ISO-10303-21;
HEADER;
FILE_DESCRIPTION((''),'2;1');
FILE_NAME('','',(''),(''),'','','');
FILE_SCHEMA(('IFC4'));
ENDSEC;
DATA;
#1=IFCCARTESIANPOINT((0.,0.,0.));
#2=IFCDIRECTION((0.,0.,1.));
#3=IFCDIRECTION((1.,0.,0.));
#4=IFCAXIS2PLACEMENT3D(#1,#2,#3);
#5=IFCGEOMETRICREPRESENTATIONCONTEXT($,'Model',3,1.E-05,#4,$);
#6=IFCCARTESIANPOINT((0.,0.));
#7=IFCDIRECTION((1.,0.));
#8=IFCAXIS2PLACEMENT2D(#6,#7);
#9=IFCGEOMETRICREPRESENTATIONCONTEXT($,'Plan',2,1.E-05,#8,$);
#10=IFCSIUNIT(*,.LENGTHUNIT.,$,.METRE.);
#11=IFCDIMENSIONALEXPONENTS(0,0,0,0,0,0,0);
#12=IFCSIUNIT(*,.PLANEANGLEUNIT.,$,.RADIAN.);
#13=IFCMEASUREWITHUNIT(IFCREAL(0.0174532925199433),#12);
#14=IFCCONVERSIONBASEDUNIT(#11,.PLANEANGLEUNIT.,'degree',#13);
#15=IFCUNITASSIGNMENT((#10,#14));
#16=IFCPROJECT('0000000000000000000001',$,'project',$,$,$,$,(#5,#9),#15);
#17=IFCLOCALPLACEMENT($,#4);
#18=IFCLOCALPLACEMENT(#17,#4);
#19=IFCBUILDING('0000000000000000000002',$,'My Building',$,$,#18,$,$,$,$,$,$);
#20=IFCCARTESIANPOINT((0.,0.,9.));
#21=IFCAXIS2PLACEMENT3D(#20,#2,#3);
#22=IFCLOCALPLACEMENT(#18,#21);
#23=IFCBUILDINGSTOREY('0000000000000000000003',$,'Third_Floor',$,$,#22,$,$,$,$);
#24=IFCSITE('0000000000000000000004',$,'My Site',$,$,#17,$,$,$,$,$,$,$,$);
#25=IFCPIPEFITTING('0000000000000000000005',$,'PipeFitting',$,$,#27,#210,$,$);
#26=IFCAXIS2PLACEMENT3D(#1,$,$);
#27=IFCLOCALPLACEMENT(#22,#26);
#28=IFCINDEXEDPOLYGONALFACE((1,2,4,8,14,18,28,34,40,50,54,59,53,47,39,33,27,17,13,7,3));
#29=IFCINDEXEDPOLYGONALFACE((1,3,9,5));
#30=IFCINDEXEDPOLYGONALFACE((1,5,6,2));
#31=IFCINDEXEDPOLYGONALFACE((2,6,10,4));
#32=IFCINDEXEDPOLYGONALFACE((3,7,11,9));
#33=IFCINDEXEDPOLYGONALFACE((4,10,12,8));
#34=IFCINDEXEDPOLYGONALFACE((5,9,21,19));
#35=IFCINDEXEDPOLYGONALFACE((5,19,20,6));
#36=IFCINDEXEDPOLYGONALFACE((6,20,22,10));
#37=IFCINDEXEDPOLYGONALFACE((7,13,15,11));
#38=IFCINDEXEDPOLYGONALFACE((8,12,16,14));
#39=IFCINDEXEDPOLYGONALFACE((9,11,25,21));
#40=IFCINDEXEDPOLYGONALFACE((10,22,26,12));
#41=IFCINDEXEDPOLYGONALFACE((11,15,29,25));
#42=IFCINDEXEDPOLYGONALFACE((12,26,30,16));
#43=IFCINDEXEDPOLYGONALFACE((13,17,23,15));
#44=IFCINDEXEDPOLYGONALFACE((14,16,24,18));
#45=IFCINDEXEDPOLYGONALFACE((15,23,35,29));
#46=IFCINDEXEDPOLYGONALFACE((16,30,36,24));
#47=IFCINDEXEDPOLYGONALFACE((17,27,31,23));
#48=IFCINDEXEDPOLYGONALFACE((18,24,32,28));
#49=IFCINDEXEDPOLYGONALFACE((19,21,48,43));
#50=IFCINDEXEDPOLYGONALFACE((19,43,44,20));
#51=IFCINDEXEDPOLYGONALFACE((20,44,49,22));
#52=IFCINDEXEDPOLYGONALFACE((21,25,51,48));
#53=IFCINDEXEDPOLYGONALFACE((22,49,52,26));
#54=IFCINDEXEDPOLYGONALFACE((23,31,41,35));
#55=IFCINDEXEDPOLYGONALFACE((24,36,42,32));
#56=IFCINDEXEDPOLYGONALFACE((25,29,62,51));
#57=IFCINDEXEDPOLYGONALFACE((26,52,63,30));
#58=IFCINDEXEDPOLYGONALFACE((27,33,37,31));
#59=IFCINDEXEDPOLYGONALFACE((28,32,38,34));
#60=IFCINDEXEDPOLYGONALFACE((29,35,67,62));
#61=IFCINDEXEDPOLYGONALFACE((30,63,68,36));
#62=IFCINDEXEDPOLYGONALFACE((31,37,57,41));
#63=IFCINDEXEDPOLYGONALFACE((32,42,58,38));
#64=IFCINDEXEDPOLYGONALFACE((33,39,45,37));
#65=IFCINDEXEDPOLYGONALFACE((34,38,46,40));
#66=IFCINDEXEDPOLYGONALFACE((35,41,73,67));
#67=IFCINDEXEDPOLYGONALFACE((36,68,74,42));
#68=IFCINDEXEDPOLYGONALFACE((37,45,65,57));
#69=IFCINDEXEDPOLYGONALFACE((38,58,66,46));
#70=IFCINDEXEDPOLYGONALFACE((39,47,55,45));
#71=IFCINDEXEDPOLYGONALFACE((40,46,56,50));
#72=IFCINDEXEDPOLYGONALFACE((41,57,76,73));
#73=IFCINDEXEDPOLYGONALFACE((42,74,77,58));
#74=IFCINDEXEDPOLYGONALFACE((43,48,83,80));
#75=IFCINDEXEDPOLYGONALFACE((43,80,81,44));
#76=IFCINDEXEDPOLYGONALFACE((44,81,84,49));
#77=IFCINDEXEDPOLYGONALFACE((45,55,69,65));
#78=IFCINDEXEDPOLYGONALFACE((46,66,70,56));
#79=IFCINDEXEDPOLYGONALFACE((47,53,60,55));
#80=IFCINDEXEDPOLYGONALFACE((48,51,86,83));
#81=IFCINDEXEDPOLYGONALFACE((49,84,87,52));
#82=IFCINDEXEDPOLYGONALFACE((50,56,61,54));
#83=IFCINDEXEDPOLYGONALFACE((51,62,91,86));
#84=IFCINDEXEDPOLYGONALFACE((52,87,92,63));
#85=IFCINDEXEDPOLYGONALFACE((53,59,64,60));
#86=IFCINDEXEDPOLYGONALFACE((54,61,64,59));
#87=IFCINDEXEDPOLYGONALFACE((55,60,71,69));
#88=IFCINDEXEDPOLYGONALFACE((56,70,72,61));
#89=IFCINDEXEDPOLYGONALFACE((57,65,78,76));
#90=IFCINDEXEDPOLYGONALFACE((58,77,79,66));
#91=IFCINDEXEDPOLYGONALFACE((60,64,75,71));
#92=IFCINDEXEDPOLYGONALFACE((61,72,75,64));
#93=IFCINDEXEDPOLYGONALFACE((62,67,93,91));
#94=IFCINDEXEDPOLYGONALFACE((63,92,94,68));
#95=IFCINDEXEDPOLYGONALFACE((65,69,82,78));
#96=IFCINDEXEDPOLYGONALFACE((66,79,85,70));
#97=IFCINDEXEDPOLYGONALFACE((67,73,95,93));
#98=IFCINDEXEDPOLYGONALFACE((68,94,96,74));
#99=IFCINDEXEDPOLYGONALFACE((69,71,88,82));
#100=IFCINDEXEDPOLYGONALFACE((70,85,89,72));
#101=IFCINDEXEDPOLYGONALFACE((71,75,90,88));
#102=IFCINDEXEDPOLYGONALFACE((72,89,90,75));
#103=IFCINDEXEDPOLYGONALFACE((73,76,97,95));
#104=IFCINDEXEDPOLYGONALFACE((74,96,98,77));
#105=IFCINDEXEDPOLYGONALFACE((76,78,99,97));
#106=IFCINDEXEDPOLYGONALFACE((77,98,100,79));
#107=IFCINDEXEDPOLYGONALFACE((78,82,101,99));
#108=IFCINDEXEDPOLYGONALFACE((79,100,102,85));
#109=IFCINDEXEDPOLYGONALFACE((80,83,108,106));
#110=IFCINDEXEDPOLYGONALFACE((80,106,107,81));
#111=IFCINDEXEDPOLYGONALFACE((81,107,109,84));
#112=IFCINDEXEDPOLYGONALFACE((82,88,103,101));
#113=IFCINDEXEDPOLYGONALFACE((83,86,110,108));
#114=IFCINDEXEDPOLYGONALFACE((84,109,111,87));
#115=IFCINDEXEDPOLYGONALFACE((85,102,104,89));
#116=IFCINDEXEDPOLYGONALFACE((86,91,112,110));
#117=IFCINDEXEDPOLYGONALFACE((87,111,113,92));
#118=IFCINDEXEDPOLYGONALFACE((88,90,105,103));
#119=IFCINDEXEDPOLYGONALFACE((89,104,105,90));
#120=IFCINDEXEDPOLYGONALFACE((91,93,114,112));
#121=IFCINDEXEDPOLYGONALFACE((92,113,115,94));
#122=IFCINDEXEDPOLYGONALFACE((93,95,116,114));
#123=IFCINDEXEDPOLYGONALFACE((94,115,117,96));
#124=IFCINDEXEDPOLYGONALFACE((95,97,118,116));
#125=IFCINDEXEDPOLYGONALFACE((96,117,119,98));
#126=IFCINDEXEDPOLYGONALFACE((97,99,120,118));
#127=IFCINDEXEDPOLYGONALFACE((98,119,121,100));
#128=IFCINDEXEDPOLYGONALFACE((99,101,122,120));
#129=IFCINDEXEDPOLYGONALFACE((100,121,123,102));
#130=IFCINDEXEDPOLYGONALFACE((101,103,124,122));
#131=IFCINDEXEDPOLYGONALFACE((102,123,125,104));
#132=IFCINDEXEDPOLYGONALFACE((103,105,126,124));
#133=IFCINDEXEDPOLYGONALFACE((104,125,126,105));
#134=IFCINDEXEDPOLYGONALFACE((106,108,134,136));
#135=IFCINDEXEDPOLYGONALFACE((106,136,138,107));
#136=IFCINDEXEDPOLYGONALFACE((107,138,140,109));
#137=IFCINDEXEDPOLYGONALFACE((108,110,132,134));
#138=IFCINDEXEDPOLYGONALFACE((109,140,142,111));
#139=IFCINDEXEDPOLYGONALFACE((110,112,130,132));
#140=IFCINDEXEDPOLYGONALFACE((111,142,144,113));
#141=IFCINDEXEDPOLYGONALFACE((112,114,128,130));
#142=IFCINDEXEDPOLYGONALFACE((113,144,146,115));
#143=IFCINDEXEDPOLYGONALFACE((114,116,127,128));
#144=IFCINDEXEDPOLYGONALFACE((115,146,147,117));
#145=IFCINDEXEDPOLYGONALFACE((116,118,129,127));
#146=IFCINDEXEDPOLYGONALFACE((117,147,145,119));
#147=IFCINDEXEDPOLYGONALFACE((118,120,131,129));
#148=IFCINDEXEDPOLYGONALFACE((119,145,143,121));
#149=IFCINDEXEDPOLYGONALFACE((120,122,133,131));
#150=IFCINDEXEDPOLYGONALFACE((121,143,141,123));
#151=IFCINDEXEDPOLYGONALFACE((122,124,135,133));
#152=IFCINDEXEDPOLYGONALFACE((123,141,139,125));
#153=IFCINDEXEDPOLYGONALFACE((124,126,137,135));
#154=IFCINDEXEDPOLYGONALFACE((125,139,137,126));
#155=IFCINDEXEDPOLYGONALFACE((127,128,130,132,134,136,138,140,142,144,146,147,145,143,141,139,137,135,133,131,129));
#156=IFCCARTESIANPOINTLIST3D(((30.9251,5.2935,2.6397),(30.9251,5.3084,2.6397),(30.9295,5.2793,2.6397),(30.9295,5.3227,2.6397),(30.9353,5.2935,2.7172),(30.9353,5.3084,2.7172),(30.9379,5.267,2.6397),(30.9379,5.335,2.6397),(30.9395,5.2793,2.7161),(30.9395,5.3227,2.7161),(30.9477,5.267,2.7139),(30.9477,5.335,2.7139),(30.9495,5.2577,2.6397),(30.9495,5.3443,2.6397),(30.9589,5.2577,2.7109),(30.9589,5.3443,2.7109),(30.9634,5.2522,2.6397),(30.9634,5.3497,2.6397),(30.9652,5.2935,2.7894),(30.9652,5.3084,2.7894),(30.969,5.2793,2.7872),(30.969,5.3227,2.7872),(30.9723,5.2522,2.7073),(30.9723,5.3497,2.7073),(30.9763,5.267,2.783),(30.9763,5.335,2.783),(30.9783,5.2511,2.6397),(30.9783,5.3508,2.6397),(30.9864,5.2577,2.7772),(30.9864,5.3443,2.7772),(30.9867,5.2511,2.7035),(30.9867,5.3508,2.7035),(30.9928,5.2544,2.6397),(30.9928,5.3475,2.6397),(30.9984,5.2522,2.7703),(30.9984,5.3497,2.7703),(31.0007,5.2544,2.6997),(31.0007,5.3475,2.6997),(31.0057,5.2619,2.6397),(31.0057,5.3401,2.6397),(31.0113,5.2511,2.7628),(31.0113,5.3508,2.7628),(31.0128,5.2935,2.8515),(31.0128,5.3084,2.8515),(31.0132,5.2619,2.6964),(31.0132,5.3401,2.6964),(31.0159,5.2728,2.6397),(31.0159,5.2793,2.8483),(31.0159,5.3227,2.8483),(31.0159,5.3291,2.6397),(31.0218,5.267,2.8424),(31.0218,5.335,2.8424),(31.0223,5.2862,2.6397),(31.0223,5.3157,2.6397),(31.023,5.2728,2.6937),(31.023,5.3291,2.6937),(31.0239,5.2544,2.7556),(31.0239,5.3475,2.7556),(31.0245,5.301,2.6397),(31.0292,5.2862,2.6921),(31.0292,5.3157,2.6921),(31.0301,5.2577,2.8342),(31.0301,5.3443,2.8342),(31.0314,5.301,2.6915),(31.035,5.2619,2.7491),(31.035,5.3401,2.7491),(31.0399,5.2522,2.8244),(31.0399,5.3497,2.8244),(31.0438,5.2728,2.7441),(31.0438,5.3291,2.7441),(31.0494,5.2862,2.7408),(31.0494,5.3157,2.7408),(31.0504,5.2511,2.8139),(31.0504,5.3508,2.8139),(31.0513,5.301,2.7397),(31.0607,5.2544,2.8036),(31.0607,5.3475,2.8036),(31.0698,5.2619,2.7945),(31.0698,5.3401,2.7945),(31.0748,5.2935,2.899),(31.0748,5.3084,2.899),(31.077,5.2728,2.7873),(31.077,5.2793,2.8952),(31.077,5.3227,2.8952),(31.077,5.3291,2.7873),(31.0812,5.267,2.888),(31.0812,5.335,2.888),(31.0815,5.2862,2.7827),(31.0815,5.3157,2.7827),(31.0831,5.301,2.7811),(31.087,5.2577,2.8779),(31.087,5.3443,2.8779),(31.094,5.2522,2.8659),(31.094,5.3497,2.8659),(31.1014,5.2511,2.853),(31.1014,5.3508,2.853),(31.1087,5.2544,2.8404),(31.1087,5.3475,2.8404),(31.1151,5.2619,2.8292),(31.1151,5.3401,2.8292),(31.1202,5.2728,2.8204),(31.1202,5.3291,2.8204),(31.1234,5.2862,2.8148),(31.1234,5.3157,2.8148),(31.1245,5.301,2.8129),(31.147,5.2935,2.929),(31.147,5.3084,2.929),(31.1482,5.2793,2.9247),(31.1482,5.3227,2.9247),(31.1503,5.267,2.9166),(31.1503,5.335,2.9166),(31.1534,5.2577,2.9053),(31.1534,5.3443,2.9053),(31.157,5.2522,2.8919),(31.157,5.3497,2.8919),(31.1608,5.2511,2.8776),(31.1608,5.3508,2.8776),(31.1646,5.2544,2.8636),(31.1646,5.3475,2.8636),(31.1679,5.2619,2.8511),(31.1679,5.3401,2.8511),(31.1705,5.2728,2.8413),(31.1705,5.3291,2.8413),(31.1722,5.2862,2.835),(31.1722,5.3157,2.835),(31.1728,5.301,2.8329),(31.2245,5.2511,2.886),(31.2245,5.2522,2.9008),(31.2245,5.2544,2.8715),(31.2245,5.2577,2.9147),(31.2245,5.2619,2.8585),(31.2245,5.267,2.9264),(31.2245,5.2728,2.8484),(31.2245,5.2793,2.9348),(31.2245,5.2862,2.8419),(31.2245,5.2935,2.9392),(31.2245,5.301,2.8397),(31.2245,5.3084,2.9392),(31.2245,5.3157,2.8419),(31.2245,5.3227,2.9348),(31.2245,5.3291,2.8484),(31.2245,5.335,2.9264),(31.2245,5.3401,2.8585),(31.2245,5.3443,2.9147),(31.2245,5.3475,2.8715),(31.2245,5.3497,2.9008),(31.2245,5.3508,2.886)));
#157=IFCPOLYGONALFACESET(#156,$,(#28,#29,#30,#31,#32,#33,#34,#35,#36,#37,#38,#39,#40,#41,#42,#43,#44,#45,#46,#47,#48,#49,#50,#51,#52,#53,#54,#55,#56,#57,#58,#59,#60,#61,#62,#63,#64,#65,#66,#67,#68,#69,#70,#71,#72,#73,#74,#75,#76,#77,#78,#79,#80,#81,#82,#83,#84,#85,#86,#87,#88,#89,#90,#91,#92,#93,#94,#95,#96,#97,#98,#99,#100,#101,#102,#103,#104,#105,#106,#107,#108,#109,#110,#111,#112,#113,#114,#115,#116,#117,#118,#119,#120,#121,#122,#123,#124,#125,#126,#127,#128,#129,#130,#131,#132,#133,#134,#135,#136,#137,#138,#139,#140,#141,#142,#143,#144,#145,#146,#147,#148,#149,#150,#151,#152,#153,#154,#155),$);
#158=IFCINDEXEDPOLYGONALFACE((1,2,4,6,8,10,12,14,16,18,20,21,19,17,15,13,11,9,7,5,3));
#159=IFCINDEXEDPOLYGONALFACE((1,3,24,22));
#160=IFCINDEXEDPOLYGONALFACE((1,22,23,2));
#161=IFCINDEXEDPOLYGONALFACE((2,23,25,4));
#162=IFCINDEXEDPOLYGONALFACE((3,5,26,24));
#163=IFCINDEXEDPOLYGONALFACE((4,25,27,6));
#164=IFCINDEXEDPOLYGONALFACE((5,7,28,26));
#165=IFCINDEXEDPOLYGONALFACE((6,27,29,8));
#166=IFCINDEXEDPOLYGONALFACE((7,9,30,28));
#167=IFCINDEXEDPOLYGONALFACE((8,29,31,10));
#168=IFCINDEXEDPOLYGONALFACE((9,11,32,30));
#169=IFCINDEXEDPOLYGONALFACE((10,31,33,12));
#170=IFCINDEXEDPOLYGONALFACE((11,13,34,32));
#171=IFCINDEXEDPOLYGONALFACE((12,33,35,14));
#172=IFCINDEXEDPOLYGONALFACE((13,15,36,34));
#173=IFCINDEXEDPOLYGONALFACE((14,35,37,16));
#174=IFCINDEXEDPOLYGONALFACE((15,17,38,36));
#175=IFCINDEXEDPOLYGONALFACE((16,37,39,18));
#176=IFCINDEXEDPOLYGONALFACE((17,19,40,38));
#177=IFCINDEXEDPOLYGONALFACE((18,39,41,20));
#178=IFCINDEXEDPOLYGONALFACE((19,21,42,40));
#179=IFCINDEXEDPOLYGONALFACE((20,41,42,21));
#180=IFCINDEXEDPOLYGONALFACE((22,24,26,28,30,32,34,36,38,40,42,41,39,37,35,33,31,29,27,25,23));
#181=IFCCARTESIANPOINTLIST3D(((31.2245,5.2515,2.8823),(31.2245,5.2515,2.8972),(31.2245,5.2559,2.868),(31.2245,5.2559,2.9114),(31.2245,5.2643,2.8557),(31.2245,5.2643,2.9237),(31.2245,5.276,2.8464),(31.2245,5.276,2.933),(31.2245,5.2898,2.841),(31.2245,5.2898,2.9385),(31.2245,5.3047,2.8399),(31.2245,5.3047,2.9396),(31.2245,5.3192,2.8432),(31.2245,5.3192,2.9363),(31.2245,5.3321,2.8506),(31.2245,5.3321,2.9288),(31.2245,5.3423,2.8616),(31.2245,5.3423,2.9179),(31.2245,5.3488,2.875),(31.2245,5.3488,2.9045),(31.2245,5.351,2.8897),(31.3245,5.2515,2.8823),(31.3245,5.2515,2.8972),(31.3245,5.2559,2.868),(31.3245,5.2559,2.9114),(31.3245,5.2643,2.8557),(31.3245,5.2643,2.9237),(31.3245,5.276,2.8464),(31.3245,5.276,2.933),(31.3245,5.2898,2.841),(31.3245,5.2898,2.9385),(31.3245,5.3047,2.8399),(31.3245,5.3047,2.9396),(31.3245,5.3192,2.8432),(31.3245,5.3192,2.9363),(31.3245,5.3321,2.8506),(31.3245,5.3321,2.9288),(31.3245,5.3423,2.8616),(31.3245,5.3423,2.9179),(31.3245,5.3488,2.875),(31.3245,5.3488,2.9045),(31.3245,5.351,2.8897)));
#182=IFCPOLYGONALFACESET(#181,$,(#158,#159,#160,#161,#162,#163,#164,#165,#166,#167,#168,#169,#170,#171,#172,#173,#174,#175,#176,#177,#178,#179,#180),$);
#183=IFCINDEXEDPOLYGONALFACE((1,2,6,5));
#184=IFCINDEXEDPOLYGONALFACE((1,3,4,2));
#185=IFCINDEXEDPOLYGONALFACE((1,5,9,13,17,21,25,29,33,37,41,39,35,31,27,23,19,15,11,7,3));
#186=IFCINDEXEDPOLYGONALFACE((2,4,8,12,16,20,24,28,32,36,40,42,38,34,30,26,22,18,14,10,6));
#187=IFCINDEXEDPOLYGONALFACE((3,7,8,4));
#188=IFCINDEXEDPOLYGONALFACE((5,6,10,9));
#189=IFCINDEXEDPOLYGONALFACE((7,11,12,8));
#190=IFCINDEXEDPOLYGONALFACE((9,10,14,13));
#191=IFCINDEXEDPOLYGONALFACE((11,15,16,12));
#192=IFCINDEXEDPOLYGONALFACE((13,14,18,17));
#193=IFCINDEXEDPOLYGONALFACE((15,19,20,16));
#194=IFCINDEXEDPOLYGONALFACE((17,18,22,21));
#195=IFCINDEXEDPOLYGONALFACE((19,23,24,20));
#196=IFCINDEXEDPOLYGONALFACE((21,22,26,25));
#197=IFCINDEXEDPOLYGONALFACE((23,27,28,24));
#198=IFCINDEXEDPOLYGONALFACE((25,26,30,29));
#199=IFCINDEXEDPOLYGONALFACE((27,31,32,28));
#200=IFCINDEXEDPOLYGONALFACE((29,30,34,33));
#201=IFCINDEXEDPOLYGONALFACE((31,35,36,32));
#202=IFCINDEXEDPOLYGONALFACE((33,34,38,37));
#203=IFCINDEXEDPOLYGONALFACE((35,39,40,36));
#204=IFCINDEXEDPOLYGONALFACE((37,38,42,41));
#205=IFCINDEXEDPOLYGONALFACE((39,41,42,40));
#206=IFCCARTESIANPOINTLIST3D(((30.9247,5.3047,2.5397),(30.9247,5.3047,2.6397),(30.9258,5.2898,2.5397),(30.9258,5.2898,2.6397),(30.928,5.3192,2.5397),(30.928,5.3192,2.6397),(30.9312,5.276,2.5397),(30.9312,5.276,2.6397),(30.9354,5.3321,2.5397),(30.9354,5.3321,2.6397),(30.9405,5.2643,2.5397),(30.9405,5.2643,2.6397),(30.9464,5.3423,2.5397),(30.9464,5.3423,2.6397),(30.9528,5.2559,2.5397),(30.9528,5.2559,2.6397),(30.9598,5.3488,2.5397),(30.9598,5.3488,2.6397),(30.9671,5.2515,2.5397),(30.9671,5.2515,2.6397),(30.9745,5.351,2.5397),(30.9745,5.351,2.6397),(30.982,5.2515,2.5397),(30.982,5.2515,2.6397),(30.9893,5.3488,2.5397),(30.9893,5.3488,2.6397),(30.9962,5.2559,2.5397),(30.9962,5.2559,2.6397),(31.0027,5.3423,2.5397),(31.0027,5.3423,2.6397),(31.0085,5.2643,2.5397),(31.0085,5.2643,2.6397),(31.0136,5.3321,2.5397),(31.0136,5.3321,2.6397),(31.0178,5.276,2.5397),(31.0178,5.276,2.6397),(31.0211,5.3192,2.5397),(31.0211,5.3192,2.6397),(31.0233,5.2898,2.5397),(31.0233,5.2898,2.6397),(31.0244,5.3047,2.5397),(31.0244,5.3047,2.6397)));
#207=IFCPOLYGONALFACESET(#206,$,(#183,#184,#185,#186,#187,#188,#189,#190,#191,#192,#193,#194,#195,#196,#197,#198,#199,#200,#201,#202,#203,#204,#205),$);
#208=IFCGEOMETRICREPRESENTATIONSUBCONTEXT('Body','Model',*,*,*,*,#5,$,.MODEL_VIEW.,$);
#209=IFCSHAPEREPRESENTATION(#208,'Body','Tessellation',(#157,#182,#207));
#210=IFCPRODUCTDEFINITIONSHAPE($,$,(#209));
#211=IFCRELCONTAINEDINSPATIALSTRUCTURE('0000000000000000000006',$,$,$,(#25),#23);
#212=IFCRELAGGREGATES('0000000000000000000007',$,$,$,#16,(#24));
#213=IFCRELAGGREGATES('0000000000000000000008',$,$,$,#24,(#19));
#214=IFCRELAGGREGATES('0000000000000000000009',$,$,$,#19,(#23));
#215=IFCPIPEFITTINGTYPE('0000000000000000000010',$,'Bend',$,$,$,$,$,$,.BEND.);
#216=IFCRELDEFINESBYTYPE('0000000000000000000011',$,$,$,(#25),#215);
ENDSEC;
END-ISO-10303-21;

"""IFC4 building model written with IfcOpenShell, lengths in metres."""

from ifc_helpers import new_model, entity, si_unit, converted_unit, frame, origin_with_axes, origin_2d_with_axis, place, context, subcontext, project, spatial, circle, extrude, source, transform, mapped, type_object, type_shapes, element, save


model = new_model("IFC4")

# Units and contexts
model_context = context("Model", 3, precision=1e-05, world=origin_with_axes())
plan_context = context("Plan", 2, precision=1e-05, world=origin_2d_with_axis())
body_context_1 = subcontext(model_context, "Body", "Model", "MODEL_VIEW")
ifc_project = project(units=[si_unit("LENGTHUNIT", "METRE"), converted_unit("PLANEANGLEUNIT", "degree", entity("IfcReal", 0.0174532925199433), si_unit("PLANEANGLEUNIT", "RADIAN"), dimensions=[0, 0, 0, 0, 0, 0, 0])], contexts=[model_context, plan_context])

# Site, building, storey
site_placement = place(None, origin_with_axes())
site = spatial("IfcSite", under=ifc_project, at=site_placement, Name="My Site")
building_placement = place(site_placement, origin_with_axes())
building = spatial("IfcBuilding", under=site, at=building_placement, Name="My Building")
storey_placement = place(building_placement, frame((0.0, 0.0, 9.0), z_axis=(0.0, 0.0, 1.0), x_axis=(1.0, 0.0, 0.0)))
storey = spatial("IfcBuildingStorey", under=building, at=storey_placement, Name="Third_Floor")

# Pipe fitting
pipe_fitting_type = type_object("IfcPipeFittingType", Name="Bend", PredefinedType="BEND")
shared_shape_1 = source(origin_with_axes(), body_context_1, "Body", "SolidModel", [
    entity("IfcSweptDiskSolid", entity("IfcIndexedPolyCurve", entity("IfcCartesianPointList3D", [[0.0, 0.0, -0.1], [0.0, -0.0732, -0.2768], [0.0, -0.25, -0.35]]), [entity("IfcArcIndex", [1, 2, 3])]), 0.05),
    extrude(circle(Radius=0.05), origin_with_axes(), (0.0, 0.0, -1.0), 0.1),
    extrude(circle(Radius=0.05), frame((0.0, -0.25, -0.35), z_axis=(0.0, -1.0, 0.0), x_axis=(1.0, 0.0, 0.0)), (0.0, 0.0, 1.0), 0.1),
])
type_shapes(pipe_fitting_type, [shared_shape_1])
for number, where, z_axis, x_axis, name in (
    (1, (31.3245, 5.301, 2.8897), (1.0, 0.000001, 0.0), (-0.000001, 1.0, 0.0), "PipeFitting"),
):
    element("IfcPipeFitting", number, at=place(storey_placement, frame(where, z_axis=z_axis, x_axis=x_axis)), inside=storey, type_object=pipe_fitting_type, Name=name, context=body_context_1, shape_type="MappedRepresentation", body=[
        mapped(shared_shape_1, transform((0.0, 0.0, 0.0), x_axis=(1.0, 0.0, 0.0), y_axis=(0.0, 1.0, 0.0), z_axis=(0.0, 0.0, 1.0), scale=1.0)),
    ])

save(model, "model.ifc")
